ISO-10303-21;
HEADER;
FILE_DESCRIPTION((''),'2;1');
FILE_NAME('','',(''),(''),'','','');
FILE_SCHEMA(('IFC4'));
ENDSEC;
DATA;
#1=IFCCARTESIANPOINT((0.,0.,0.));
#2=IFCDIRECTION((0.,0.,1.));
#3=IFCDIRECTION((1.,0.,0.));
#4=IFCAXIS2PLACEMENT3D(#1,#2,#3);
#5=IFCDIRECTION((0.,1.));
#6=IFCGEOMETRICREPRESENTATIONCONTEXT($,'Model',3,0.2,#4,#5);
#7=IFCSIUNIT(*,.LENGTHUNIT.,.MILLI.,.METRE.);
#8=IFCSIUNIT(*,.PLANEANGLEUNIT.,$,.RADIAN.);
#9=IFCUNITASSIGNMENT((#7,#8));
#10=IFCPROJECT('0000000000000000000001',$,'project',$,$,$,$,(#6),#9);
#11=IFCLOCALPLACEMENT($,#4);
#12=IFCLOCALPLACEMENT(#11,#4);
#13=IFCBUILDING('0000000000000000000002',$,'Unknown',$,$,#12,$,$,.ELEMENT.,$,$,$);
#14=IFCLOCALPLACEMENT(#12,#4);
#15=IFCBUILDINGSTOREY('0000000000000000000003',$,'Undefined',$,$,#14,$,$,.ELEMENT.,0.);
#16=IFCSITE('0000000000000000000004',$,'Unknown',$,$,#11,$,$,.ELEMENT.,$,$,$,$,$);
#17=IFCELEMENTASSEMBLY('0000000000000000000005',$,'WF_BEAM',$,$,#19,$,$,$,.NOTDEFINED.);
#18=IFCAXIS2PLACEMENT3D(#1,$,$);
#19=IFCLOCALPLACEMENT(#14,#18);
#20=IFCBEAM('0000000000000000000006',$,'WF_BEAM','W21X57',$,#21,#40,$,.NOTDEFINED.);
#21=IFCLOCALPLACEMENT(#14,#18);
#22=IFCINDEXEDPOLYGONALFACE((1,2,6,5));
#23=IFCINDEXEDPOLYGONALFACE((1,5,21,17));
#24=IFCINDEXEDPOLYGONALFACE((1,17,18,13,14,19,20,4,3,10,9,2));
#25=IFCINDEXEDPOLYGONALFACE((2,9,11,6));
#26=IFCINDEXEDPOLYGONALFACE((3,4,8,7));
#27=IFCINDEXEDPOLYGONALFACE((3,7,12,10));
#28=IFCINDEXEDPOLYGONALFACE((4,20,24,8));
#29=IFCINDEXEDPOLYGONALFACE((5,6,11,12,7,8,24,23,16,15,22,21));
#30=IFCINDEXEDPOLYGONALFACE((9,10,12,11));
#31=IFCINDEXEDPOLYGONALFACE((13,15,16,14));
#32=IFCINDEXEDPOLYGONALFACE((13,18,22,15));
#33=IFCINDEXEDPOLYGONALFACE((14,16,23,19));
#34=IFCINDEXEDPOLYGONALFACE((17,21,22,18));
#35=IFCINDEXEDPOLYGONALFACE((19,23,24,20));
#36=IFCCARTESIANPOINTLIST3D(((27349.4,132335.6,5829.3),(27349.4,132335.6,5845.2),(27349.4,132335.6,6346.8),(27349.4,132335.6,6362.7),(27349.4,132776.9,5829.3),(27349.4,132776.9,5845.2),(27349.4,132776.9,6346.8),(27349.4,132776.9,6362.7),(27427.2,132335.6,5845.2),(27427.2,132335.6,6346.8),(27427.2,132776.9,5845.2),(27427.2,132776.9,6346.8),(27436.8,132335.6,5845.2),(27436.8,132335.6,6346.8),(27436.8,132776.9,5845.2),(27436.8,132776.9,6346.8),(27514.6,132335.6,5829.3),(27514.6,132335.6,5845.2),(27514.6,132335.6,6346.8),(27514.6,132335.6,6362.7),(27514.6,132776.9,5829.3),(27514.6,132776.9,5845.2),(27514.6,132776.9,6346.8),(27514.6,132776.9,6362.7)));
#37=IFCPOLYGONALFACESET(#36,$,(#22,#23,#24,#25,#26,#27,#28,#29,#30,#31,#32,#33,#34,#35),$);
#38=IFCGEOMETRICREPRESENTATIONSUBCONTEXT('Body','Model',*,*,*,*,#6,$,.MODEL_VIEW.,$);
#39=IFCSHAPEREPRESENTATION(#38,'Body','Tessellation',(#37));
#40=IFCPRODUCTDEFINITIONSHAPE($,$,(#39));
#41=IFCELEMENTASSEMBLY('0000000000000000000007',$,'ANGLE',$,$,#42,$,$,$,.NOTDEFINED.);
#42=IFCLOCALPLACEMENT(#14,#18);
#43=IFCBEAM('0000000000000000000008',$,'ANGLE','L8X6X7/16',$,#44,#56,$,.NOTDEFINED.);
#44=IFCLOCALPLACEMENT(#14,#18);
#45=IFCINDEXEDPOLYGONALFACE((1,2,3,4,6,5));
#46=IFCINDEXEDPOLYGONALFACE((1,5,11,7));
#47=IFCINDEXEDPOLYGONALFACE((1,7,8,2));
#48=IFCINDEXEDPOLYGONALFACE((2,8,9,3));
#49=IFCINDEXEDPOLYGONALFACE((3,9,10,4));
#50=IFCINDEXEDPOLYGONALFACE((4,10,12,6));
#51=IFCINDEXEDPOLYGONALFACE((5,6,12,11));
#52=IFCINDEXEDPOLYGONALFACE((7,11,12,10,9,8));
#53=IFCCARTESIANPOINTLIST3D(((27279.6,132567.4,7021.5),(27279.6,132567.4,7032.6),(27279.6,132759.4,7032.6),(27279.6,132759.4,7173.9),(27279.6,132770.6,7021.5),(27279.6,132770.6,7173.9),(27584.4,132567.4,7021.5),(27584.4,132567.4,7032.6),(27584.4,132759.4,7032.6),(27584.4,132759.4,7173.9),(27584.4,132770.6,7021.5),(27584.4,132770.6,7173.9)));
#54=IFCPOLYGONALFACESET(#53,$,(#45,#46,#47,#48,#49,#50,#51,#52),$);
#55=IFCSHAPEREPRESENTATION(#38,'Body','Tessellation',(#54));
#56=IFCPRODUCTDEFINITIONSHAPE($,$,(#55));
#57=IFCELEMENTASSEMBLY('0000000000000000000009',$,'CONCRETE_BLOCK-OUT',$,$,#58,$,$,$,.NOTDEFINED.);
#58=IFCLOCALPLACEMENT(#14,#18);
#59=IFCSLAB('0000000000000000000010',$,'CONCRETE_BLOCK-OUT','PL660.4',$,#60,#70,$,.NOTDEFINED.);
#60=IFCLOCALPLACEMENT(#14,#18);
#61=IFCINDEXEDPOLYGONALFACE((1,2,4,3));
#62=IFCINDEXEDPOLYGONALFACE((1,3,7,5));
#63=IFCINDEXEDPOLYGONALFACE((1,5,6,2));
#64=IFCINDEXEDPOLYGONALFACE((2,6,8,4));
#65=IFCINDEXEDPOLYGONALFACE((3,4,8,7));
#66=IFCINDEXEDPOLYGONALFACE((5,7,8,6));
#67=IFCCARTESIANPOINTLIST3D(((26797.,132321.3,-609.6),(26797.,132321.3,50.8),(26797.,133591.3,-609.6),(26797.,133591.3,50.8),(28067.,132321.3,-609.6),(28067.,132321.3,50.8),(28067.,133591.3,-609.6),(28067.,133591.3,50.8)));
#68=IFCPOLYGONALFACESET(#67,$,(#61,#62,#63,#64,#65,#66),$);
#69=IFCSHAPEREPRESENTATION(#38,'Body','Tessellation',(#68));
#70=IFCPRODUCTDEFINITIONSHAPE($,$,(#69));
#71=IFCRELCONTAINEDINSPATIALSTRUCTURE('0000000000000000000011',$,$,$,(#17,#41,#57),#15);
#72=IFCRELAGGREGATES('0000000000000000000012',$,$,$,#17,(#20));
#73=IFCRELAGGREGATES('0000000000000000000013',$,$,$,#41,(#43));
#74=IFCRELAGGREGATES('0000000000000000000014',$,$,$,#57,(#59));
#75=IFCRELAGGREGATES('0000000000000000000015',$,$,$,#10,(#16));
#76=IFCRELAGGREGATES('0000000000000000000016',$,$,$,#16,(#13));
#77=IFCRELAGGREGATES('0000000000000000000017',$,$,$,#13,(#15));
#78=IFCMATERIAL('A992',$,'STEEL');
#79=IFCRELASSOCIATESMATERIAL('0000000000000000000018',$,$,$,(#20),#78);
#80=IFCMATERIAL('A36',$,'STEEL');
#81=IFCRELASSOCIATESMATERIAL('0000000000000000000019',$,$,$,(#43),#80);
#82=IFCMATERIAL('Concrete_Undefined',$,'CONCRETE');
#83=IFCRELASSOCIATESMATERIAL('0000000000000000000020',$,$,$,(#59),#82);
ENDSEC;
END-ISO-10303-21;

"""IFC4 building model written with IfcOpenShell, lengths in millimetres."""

from ifc_helpers import new_model, si_unit, direction, frame, origin_with_axes, place, context, subcontext, project, spatial, line, indexed_curve, outline, extrude, material, element, aggregate, save


model = new_model("IFC4")

# Units and contexts
model_context = context("Model", 3, precision=0.2, world=origin_with_axes(), true_north=direction((0.0, 1.0)))
body_context = subcontext(model_context, "Body", "Model", "MODEL_VIEW")
ifc_project = project(units=[si_unit("LENGTHUNIT", "METRE", prefix="MILLI"), si_unit("PLANEANGLEUNIT", "RADIAN")], contexts=[model_context])

# Site, building, storey
site_placement = place(None, origin_with_axes())
site = spatial("IfcSite", under=ifc_project, at=site_placement, Name="Unknown", CompositionType="ELEMENT")
building_placement = place(site_placement, origin_with_axes())
building = spatial("IfcBuilding", under=site, at=building_placement, Name="Unknown", CompositionType="ELEMENT")
storey_placement = place(building_placement, origin_with_axes())
storey = spatial("IfcBuildingStorey", under=building, at=storey_placement, Name="Undefined", CompositionType="ELEMENT", Elevation=0.0)

# Shared definitions
ifc_material_1 = material(Name="A992", Category="STEEL")

# Element assemblies, beams
ifc_material_2 = material(Name="A36", Category="STEEL")
assembly_1_placement = place(storey_placement, frame((27432.0, 132335.6, 6096.0), z_axis=(1.0, 0.0, 0.0), x_axis=(0.0, 1.0, 0.0)))
assembly_1 = element("IfcElementAssembly", 1, at=assembly_1_placement, inside=storey, Name="WF_BEAM", PredefinedType="NOTDEFINED")
beam_1_placement = place(assembly_1_placement, origin_with_axes())
beam_1 = element("IfcBeam", 2, at=beam_1_placement, material=ifc_material_1, Name="WF_BEAM", Description="W21X57", PredefinedType="NOTDEFINED", context=body_context, shape_type="SolidModel", body=[
    extrude(outline(indexed_curve([(-82.5, -266.7), (82.5, -266.7), (82.5, -250.8), (4.8, -250.8), (4.8, 250.8), (82.5, 250.8), (82.5, 266.7), (-82.5, 266.7), (-82.5, 250.8), (-4.8, 250.8), (-4.8, -250.8), (-82.5, -250.8)], segments=[line(1, 2, 3, 4, 5, 6, 7, 8, 9, 10, 11, 12, 1)])), frame((0.0, 0.0, 0.0), z_axis=(-1.0, 0.0, 0.0), x_axis=(0.0, 0.0, 1.0)), (0.0, 0.0, -1.0), 441.3),
])
aggregate(assembly_1, [beam_1])
assembly_2_placement = place(storey_placement, frame((27584.4, 132669.0, 7097.7), z_axis=(0.0, 0.0, 1.0), x_axis=(-1.0, 0.000019, 0.0)))
assembly_2 = element("IfcElementAssembly", 3, at=assembly_2_placement, inside=storey, Name="ANGLE", PredefinedType="NOTDEFINED")
beam_2_placement = place(assembly_2_placement, origin_with_axes())
beam_2 = element("IfcBeam", 4, at=beam_2_placement, material=ifc_material_2, Name="ANGLE", Description="L8X6X7/16", PredefinedType="NOTDEFINED", context=body_context, shape_type="SolidModel", body=[
    extrude(outline(indexed_curve([(-76.2, -101.6), (76.2, -101.6), (76.2, -90.5), (-65.1, -90.5), (-65.1, 101.6), (-76.2, 101.6)], segments=[line(1, 2, 3, 4, 5, 6, 1)])), frame((0.0, 0.0, 0.0), z_axis=(-1.0, 0.0, 0.0), x_axis=(0.0, 0.0, 1.0)), (0.0, 0.0, -1.0), 304.8),
])
aggregate(assembly_2, [beam_2])

# Element assembly, slab
assembly_3_placement = place(storey_placement, frame((28067.0, 133591.3, -279.4), z_axis=(0.0, 0.0, 1.0), x_axis=(-1.0, 0.0, 0.0)))
assembly_3 = element("IfcElementAssembly", 5, at=assembly_3_placement, inside=storey, Name="CONCRETE_BLOCK-OUT", PredefinedType="NOTDEFINED")
ifc_material_3 = material(Name="Concrete_Undefined", Category="CONCRETE")
slab_placement = place(assembly_3_placement, origin_with_axes())
slab = element("IfcSlab", 6, at=slab_placement, material=ifc_material_3, Name="CONCRETE_BLOCK-OUT", Description="PL660.4", PredefinedType="NOTDEFINED", context=body_context, shape_type="SolidModel", body=[
    extrude(outline(indexed_curve([(0.0, 0.0), (1270.0, 0.0), (1270.0, 1270.0), (0.0, 1270.0)], segments=[line(1, 2, 3, 4, 1)])), frame((0.0, 0.0, 330.2), z_axis=(0.0, 0.0, 1.0), x_axis=(1.0, 0.0, 0.0)), (0.0, 0.0, -1.0), 660.4),
])
aggregate(assembly_3, [slab])

save(model, "model.ifc")
